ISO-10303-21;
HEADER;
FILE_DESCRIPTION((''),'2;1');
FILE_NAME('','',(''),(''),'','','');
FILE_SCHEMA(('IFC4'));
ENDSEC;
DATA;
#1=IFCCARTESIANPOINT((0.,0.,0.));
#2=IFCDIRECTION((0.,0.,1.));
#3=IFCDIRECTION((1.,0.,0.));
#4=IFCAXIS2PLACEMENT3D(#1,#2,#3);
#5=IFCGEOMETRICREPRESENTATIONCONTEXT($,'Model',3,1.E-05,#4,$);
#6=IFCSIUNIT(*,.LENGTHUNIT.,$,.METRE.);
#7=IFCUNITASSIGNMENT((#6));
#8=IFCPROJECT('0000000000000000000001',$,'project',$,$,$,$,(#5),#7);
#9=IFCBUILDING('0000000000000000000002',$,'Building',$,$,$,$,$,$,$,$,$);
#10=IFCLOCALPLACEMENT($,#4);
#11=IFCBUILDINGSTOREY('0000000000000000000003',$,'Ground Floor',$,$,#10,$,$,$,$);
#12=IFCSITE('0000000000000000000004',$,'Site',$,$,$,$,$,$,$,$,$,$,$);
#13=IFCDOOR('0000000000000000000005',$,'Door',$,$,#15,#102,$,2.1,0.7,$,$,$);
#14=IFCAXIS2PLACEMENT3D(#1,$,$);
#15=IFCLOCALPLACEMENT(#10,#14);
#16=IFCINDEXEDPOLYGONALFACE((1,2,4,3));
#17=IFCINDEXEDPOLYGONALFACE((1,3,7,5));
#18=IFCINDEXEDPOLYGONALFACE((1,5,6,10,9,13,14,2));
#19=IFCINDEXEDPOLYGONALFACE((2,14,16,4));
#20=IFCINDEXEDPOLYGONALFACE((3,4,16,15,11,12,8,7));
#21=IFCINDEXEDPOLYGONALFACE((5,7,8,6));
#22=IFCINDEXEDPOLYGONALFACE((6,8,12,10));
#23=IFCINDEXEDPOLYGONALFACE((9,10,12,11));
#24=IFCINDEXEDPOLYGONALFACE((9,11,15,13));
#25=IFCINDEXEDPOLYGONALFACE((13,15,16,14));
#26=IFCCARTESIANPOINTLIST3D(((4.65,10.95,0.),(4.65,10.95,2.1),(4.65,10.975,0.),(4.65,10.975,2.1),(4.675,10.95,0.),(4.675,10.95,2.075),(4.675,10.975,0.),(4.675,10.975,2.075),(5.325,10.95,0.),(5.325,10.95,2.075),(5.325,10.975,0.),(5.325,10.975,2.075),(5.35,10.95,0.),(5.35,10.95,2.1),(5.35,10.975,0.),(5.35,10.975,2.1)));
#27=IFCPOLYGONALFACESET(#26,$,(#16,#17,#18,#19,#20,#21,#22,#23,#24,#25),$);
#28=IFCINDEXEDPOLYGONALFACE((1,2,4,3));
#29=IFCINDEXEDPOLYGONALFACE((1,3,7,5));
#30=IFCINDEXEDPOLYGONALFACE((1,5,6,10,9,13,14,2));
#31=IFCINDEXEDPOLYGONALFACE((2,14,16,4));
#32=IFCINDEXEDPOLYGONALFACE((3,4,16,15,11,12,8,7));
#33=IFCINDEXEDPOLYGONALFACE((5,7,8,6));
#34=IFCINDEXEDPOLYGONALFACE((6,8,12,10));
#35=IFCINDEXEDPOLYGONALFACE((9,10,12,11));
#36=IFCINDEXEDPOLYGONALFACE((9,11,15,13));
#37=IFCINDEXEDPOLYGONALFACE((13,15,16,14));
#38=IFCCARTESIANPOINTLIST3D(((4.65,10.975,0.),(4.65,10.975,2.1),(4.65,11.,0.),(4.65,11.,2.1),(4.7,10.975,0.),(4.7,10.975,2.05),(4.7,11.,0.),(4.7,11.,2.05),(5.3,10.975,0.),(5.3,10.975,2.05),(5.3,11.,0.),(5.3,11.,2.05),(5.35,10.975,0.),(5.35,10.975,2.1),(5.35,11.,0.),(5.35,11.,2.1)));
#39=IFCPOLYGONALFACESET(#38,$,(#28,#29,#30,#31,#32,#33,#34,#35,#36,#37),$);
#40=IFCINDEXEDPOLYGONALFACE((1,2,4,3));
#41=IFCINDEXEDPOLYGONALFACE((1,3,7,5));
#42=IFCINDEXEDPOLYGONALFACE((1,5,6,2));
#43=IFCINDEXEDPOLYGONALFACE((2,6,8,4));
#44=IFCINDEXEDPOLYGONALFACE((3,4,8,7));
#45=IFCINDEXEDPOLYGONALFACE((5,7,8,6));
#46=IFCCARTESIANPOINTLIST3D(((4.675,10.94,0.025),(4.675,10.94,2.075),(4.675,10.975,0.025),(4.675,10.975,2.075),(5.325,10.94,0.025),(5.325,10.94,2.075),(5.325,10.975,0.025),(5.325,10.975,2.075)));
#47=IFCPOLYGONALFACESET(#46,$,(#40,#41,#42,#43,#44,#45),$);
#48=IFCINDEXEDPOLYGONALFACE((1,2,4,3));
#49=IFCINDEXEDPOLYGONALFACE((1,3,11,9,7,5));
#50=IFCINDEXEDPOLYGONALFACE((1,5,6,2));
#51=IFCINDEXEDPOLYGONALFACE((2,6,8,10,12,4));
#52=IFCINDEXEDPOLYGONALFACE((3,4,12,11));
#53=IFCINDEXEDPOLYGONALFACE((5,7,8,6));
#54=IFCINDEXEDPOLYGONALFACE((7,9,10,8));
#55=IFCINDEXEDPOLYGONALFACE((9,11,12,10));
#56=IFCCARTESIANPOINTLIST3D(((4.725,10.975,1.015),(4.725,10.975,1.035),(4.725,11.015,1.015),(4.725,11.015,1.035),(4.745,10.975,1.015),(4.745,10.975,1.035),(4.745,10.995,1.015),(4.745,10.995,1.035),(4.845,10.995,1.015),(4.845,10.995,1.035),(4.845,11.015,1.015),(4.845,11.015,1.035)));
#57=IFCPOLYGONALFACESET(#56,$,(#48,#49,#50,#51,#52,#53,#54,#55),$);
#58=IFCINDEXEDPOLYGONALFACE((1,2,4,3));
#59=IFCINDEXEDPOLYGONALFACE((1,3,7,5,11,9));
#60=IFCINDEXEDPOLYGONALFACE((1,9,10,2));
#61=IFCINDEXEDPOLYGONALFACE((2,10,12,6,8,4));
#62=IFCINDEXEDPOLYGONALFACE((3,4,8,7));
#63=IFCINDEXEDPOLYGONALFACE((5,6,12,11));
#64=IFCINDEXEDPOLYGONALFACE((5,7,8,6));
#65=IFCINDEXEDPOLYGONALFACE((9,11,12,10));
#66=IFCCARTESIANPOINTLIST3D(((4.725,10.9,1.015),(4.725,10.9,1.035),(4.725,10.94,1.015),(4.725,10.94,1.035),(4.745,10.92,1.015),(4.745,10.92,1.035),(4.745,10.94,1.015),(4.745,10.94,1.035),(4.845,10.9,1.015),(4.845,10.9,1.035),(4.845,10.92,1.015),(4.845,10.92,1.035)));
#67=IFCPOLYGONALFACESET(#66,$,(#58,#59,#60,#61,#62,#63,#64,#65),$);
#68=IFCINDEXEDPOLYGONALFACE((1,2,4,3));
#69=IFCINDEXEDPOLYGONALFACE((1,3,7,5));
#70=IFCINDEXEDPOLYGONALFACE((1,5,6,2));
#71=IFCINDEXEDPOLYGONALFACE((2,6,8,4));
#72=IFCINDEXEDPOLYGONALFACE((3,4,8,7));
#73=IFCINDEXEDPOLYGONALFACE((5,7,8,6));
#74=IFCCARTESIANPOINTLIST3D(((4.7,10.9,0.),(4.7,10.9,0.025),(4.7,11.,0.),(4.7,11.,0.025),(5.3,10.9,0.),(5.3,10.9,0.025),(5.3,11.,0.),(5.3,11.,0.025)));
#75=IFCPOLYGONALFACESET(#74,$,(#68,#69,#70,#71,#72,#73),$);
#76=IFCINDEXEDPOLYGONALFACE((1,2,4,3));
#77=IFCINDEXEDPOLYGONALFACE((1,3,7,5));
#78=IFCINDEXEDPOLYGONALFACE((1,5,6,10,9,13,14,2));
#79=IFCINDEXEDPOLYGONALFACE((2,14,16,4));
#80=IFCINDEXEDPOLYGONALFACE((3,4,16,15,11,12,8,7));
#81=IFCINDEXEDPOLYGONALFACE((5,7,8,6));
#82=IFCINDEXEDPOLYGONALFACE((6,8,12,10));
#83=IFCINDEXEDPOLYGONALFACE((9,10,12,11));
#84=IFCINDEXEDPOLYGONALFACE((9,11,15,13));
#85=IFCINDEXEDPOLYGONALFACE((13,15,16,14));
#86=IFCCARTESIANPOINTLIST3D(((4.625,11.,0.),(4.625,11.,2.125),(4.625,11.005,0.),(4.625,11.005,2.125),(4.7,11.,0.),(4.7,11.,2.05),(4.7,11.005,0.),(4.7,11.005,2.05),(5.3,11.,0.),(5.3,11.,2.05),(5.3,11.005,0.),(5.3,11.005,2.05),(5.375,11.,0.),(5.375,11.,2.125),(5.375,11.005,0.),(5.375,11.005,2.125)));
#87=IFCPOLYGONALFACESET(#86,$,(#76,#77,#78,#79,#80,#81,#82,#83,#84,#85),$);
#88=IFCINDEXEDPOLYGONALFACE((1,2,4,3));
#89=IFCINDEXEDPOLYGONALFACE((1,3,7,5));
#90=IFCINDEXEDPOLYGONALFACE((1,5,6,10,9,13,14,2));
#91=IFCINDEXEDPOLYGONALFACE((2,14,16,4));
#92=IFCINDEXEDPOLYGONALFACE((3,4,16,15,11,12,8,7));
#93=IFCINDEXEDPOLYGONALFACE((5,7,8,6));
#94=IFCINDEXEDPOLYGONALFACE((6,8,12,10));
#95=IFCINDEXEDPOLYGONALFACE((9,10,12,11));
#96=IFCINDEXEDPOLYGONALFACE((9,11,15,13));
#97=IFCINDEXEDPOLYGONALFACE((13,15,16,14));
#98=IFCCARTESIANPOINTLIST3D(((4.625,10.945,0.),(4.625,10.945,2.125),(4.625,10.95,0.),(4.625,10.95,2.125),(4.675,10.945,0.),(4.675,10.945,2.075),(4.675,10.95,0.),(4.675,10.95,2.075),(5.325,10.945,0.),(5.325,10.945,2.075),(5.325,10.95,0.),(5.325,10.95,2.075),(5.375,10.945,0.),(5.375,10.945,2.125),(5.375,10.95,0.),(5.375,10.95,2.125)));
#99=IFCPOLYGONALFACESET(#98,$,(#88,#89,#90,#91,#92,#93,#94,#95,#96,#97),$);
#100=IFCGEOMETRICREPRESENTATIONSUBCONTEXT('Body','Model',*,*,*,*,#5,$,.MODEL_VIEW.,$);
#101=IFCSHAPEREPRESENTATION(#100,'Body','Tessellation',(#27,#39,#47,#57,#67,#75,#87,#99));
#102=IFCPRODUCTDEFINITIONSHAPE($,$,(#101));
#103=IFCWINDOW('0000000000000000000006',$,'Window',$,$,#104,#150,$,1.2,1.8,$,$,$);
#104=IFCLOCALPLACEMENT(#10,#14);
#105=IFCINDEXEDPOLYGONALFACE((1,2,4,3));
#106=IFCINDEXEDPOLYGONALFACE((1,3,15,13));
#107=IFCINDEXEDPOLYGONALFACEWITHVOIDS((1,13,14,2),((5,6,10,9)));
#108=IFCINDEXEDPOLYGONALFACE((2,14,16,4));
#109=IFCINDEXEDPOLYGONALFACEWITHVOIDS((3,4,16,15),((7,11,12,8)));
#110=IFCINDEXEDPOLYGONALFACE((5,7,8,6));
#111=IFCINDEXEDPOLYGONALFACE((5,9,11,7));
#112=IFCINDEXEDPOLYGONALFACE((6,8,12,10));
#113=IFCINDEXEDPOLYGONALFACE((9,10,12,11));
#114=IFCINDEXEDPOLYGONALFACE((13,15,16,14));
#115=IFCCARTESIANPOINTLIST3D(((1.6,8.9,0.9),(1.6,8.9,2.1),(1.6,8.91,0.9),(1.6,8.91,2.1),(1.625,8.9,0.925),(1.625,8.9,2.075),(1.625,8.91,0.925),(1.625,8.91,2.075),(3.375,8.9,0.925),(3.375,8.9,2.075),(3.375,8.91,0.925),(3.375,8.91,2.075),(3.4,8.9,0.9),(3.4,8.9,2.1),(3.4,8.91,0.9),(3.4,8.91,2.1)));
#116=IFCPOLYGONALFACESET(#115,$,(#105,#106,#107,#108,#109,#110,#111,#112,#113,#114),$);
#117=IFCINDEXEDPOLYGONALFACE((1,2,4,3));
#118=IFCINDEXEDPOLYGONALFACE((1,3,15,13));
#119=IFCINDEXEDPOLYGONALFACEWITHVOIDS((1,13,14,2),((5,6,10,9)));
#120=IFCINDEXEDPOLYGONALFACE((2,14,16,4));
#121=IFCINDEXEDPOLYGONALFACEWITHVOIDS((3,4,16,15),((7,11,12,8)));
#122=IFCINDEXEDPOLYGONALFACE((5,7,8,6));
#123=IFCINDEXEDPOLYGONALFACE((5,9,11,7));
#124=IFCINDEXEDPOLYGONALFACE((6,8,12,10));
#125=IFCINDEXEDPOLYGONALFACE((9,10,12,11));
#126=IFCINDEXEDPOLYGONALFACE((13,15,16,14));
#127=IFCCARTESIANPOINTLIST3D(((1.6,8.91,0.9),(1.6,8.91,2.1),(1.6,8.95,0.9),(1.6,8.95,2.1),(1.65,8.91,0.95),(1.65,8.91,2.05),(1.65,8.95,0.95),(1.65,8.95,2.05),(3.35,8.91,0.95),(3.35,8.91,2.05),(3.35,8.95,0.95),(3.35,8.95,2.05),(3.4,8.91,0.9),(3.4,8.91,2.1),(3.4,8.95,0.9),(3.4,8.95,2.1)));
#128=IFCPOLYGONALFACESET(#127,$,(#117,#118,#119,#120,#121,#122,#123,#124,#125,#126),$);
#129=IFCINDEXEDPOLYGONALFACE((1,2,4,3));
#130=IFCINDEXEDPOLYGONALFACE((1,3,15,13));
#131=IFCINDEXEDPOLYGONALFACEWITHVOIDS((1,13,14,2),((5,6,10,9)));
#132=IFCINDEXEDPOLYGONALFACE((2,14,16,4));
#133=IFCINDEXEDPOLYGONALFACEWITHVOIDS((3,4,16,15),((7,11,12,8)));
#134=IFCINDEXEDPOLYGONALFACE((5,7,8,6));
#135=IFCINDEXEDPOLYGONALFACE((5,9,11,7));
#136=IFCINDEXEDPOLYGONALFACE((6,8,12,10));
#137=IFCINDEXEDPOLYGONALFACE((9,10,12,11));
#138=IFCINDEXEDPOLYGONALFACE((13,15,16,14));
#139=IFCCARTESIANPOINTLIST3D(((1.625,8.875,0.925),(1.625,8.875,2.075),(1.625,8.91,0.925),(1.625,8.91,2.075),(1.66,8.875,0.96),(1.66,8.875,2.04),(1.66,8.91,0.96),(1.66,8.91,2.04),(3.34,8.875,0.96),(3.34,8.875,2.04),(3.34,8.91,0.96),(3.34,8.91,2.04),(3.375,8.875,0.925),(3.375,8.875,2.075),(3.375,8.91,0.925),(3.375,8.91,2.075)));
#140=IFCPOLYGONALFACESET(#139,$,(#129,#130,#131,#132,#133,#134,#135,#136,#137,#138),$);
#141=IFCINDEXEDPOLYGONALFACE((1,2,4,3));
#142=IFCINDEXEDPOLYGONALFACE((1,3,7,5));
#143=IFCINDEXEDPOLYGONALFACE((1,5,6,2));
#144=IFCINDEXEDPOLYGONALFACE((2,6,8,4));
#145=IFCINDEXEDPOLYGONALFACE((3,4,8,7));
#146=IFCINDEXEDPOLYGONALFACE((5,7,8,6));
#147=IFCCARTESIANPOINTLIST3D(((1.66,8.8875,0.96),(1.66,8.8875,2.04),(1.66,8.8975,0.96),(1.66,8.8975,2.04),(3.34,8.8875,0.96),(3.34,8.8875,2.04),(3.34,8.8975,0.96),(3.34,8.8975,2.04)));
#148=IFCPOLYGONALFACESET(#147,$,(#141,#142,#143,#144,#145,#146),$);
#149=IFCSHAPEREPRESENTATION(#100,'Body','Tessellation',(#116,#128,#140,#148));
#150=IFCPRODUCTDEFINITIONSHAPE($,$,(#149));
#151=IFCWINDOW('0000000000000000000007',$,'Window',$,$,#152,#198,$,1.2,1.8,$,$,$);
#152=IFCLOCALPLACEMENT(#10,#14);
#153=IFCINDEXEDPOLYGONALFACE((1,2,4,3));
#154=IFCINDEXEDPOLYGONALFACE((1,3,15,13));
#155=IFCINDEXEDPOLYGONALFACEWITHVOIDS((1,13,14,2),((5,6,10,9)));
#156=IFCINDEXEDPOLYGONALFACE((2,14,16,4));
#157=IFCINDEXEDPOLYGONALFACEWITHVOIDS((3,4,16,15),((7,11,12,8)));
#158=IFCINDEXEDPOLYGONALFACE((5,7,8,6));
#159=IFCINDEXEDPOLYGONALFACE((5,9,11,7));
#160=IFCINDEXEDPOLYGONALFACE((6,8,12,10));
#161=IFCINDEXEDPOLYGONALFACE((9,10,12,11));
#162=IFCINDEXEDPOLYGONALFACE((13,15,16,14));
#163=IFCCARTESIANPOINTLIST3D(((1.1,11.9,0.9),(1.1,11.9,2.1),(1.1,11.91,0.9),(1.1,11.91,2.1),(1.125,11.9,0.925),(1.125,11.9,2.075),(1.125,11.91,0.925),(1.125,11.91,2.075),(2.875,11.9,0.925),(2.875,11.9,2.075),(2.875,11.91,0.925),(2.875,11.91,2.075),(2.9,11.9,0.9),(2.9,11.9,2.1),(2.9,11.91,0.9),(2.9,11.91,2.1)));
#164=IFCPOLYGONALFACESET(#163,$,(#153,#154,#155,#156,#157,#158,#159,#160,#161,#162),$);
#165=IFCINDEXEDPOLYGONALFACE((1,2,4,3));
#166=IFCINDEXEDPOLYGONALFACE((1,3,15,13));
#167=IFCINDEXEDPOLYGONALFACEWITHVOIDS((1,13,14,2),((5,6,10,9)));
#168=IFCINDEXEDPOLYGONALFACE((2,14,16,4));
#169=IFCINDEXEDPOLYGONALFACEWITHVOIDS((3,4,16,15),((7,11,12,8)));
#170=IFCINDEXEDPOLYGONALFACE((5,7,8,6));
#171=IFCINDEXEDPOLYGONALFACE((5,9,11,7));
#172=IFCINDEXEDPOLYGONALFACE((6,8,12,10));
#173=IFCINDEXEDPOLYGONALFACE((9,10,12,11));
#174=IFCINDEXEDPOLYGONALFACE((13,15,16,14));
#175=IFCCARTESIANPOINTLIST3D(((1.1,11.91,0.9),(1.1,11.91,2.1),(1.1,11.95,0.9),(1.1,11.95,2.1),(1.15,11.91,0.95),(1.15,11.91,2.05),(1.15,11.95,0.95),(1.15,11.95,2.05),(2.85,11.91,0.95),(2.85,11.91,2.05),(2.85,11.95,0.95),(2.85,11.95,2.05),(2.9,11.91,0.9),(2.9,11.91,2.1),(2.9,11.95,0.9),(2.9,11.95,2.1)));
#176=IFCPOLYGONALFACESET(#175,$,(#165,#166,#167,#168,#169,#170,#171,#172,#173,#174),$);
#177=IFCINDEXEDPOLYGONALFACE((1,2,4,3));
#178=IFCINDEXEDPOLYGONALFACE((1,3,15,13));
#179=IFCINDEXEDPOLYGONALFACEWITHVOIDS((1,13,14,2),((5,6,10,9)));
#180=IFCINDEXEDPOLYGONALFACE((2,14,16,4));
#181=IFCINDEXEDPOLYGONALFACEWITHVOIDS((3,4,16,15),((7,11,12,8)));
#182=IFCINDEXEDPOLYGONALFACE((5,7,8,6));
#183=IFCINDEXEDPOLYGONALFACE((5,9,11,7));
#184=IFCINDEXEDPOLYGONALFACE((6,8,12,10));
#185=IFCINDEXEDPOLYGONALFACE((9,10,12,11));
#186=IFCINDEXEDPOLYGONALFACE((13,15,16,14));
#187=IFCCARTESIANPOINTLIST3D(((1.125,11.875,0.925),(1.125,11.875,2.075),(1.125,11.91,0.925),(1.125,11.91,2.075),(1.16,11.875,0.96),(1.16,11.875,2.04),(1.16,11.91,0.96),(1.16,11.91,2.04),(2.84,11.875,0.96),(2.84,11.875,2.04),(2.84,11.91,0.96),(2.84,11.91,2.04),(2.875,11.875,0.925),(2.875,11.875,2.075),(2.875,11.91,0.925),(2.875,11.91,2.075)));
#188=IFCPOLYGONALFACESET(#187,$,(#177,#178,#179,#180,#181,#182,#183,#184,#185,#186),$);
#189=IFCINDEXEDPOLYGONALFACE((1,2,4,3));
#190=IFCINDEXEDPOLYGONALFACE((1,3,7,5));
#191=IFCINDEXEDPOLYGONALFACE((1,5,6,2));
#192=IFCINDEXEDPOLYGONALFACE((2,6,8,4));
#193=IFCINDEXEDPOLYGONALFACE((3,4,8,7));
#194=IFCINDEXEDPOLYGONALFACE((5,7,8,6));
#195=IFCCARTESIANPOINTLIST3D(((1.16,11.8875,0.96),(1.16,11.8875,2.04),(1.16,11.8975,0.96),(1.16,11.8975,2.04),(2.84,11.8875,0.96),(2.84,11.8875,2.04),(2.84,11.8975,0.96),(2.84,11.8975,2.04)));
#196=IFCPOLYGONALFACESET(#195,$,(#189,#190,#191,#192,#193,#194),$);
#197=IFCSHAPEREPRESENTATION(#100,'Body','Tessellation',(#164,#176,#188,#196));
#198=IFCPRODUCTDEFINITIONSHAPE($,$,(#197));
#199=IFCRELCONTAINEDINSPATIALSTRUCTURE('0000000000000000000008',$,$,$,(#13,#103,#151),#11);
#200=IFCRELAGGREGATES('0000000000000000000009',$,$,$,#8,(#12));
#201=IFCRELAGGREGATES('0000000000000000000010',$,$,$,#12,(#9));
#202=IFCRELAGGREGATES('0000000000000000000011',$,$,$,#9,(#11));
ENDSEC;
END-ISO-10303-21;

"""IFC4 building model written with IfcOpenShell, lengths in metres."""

from ifc_helpers import new_model, si_unit, frame, origin_with_axes, place, context, subcontext, project, spatial, line, indexed_curve, outline, extrude, element, save


model = new_model("IFC4")

# Units and contexts
model_context = context("Model", 3, precision=1e-05, world=origin_with_axes())
body_context = subcontext(model_context, "Body", "Model", "MODEL_VIEW")
ifc_project = project(units=[si_unit("LENGTHUNIT", "METRE")], contexts=[model_context])

# Site, building, storey
site = spatial("IfcSite", under=ifc_project, Name="Site")
building = spatial("IfcBuilding", under=site, Name="Building")
storey_placement = place(None, origin_with_axes())
storey = spatial("IfcBuildingStorey", under=building, at=storey_placement, Name="Ground Floor")

# Door
door_1_placement = place(storey_placement, frame((5.35, 11.0, 0.0), z_axis=(0.0, 0.0, 1.0), x_axis=(-1.0, 0.0, 0.0)))
element("IfcDoor", 1, at=door_1_placement, inside=storey, Name="Door", OverallHeight=2.1, OverallWidth=0.7, context=body_context, shape_type="SweptSolid", body=[
    extrude(outline(indexed_curve([(0.0, 0.0), (0.0, 2.1), (0.7, 2.1), (0.7, 0.0), (0.675, 0.0), (0.675, 2.075), (0.025, 2.075), (0.025, 0.0)], segments=[line(1, 2, 3, 4, 5, 6, 7, 8, 1)])), frame((0.0, 0.025, 0.0), z_axis=(0.0, -1.0, 0.0), x_axis=(1.0, 0.0, 0.0)), (0.0, 0.0, -1.0), 0.025),
    extrude(outline(indexed_curve([(0.0, 0.0), (0.0, 2.1), (0.7, 2.1), (0.7, 0.0), (0.65, 0.0), (0.65, 2.05), (0.05, 2.05), (0.05, 0.0)], segments=[line(1, 2, 3, 4, 5, 6, 7, 8, 1)])), frame((0.0, 0.0, 0.0), z_axis=(0.0, -1.0, 0.0), x_axis=(1.0, 0.0, 0.0)), (0.0, 0.0, -1.0), 0.025),
    extrude(outline(indexed_curve([(0.0, 0.0), (0.65, 0.0), (0.65, 0.035), (0.0, 0.035)], segments=[line(1, 2, 3, 4, 1)])), frame((0.025, 0.025, 0.025), z_axis=(0.0, 0.0, 1.0), x_axis=(1.0, 0.0, 0.0)), (0.0, 0.0, 1.0), 2.05),
    extrude(outline(indexed_curve([(0.0, 0.0), (0.0, -0.04), (-0.12, -0.04), (-0.12, -0.02), (-0.02, -0.02), (-0.02, 0.0)], segments=[line(1, 2, 3, 4, 5, 6, 1)])), frame((0.625, 0.025, 1.015), z_axis=(0.0, 0.0, 1.0), x_axis=(1.0, 0.0, 0.0)), (0.0, 0.0, 1.0), 0.02),
    extrude(outline(indexed_curve([(0.0, 0.0), (0.0, 0.04), (-0.12, 0.04), (-0.12, 0.02), (-0.02, 0.02), (-0.02, 0.0)], segments=[line(1, 2, 3, 4, 5, 6, 1)])), frame((0.625, 0.06, 1.015), z_axis=(0.0, 0.0, 1.0), x_axis=(1.0, 0.0, 0.0)), (0.0, 0.0, 1.0), 0.02),
    extrude(outline(indexed_curve([(0.0, 0.0), (0.6, 0.0), (0.6, 0.1), (0.0, 0.1)], segments=[line(1, 2, 3, 4, 1)])), frame((0.05, 0.0, 0.0), z_axis=(0.0, 0.0, 1.0), x_axis=(1.0, 0.0, 0.0)), (0.0, 0.0, 1.0), 0.025),
    extrude(outline(indexed_curve([(0.0, 0.0), (0.0, 2.125), (0.75, 2.125), (0.75, 0.0), (0.675, 0.0), (0.675, 2.05), (0.075, 2.05), (0.075, 0.0)], segments=[line(1, 2, 3, 4, 5, 6, 7, 8, 1)])), frame((-0.025, -0.005, 0.0), z_axis=(0.0, -1.0, 0.0), x_axis=(1.0, 0.0, 0.0)), (0.0, 0.0, -1.0), 0.005),
    extrude(outline(indexed_curve([(0.0, 0.0), (0.0, 2.125), (0.75, 2.125), (0.75, 0.0), (0.7, 0.0), (0.7, 2.075), (0.05, 2.075), (0.05, 0.0)], segments=[line(1, 2, 3, 4, 5, 6, 7, 8, 1)])), frame((-0.025, 0.05, 0.0), z_axis=(0.0, -1.0, 0.0), x_axis=(1.0, 0.0, 0.0)), (0.0, 0.0, -1.0), 0.005),
])

# Windows
for number, where, z_axis, x_axis, name in (
    (2, (3.4, 9.0, 0.9), (0.0, 0.0, 1.0), (-1.0, 0.0, 0.0), "Window"),
    (3, (2.9, 12.0, 0.9), (0.0, 0.0, 1.0), (-1.0, 0.0, 0.0), "Window"),
):
    element("IfcWindow", number, at=place(storey_placement, frame(where, z_axis=z_axis, x_axis=x_axis)), inside=storey, Name=name, OverallHeight=1.2, OverallWidth=1.8, context=body_context, shape_type="SweptSolid", body=[
        extrude(outline(indexed_curve([(0.0, 0.0), (1.8, 0.0), (1.8, 1.2), (0.0, 1.2)], segments=[line(1, 2, 3, 4, 1)]), holes=[indexed_curve([(0.025, 0.025), (1.775, 0.025), (1.775, 1.175), (0.025, 1.175)], segments=[line(1, 2, 3, 4, 1)])]), frame((0.0, 0.09, 0.0), z_axis=(0.0, -1.0, 0.0), x_axis=(1.0, 0.0, 0.0)), (0.0, 0.0, -1.0), 0.01),
        extrude(outline(indexed_curve([(0.0, 0.0), (1.8, 0.0), (1.8, 1.2), (0.0, 1.2)], segments=[line(1, 2, 3, 4, 1)]), holes=[indexed_curve([(0.05, 0.05), (1.75, 0.05), (1.75, 1.15), (0.05, 1.15)], segments=[line(1, 2, 3, 4, 1)])]), frame((0.0, 0.05, 0.0), z_axis=(0.0, -1.0, 0.0), x_axis=(1.0, 0.0, 0.0)), (0.0, 0.0, -1.0), 0.04),
        extrude(outline(indexed_curve([(0.0, 0.0), (1.75, 0.0), (1.75, 1.15), (0.0, 1.15)], segments=[line(1, 2, 3, 4, 1)]), holes=[indexed_curve([(0.035, 0.035), (1.715, 0.035), (1.715, 1.115), (0.035, 1.115)], segments=[line(1, 2, 3, 4, 1)])]), frame((0.025, 0.09, 0.025), z_axis=(0.0, -1.0, 0.0), x_axis=(1.0, 0.0, 0.0)), (0.0, 0.0, -1.0), 0.035),
        extrude(outline(indexed_curve([(0.035, 0.035), (1.715, 0.035), (1.715, 1.115), (0.035, 1.115)], segments=[line(1, 2, 3, 4, 1)])), frame((0.025, 0.1025, 0.025), z_axis=(0.0, -1.0, 0.0), x_axis=(1.0, 0.0, 0.0)), (0.0, 0.0, -1.0), 0.01),
    ])

save(model, "model.ifc")
